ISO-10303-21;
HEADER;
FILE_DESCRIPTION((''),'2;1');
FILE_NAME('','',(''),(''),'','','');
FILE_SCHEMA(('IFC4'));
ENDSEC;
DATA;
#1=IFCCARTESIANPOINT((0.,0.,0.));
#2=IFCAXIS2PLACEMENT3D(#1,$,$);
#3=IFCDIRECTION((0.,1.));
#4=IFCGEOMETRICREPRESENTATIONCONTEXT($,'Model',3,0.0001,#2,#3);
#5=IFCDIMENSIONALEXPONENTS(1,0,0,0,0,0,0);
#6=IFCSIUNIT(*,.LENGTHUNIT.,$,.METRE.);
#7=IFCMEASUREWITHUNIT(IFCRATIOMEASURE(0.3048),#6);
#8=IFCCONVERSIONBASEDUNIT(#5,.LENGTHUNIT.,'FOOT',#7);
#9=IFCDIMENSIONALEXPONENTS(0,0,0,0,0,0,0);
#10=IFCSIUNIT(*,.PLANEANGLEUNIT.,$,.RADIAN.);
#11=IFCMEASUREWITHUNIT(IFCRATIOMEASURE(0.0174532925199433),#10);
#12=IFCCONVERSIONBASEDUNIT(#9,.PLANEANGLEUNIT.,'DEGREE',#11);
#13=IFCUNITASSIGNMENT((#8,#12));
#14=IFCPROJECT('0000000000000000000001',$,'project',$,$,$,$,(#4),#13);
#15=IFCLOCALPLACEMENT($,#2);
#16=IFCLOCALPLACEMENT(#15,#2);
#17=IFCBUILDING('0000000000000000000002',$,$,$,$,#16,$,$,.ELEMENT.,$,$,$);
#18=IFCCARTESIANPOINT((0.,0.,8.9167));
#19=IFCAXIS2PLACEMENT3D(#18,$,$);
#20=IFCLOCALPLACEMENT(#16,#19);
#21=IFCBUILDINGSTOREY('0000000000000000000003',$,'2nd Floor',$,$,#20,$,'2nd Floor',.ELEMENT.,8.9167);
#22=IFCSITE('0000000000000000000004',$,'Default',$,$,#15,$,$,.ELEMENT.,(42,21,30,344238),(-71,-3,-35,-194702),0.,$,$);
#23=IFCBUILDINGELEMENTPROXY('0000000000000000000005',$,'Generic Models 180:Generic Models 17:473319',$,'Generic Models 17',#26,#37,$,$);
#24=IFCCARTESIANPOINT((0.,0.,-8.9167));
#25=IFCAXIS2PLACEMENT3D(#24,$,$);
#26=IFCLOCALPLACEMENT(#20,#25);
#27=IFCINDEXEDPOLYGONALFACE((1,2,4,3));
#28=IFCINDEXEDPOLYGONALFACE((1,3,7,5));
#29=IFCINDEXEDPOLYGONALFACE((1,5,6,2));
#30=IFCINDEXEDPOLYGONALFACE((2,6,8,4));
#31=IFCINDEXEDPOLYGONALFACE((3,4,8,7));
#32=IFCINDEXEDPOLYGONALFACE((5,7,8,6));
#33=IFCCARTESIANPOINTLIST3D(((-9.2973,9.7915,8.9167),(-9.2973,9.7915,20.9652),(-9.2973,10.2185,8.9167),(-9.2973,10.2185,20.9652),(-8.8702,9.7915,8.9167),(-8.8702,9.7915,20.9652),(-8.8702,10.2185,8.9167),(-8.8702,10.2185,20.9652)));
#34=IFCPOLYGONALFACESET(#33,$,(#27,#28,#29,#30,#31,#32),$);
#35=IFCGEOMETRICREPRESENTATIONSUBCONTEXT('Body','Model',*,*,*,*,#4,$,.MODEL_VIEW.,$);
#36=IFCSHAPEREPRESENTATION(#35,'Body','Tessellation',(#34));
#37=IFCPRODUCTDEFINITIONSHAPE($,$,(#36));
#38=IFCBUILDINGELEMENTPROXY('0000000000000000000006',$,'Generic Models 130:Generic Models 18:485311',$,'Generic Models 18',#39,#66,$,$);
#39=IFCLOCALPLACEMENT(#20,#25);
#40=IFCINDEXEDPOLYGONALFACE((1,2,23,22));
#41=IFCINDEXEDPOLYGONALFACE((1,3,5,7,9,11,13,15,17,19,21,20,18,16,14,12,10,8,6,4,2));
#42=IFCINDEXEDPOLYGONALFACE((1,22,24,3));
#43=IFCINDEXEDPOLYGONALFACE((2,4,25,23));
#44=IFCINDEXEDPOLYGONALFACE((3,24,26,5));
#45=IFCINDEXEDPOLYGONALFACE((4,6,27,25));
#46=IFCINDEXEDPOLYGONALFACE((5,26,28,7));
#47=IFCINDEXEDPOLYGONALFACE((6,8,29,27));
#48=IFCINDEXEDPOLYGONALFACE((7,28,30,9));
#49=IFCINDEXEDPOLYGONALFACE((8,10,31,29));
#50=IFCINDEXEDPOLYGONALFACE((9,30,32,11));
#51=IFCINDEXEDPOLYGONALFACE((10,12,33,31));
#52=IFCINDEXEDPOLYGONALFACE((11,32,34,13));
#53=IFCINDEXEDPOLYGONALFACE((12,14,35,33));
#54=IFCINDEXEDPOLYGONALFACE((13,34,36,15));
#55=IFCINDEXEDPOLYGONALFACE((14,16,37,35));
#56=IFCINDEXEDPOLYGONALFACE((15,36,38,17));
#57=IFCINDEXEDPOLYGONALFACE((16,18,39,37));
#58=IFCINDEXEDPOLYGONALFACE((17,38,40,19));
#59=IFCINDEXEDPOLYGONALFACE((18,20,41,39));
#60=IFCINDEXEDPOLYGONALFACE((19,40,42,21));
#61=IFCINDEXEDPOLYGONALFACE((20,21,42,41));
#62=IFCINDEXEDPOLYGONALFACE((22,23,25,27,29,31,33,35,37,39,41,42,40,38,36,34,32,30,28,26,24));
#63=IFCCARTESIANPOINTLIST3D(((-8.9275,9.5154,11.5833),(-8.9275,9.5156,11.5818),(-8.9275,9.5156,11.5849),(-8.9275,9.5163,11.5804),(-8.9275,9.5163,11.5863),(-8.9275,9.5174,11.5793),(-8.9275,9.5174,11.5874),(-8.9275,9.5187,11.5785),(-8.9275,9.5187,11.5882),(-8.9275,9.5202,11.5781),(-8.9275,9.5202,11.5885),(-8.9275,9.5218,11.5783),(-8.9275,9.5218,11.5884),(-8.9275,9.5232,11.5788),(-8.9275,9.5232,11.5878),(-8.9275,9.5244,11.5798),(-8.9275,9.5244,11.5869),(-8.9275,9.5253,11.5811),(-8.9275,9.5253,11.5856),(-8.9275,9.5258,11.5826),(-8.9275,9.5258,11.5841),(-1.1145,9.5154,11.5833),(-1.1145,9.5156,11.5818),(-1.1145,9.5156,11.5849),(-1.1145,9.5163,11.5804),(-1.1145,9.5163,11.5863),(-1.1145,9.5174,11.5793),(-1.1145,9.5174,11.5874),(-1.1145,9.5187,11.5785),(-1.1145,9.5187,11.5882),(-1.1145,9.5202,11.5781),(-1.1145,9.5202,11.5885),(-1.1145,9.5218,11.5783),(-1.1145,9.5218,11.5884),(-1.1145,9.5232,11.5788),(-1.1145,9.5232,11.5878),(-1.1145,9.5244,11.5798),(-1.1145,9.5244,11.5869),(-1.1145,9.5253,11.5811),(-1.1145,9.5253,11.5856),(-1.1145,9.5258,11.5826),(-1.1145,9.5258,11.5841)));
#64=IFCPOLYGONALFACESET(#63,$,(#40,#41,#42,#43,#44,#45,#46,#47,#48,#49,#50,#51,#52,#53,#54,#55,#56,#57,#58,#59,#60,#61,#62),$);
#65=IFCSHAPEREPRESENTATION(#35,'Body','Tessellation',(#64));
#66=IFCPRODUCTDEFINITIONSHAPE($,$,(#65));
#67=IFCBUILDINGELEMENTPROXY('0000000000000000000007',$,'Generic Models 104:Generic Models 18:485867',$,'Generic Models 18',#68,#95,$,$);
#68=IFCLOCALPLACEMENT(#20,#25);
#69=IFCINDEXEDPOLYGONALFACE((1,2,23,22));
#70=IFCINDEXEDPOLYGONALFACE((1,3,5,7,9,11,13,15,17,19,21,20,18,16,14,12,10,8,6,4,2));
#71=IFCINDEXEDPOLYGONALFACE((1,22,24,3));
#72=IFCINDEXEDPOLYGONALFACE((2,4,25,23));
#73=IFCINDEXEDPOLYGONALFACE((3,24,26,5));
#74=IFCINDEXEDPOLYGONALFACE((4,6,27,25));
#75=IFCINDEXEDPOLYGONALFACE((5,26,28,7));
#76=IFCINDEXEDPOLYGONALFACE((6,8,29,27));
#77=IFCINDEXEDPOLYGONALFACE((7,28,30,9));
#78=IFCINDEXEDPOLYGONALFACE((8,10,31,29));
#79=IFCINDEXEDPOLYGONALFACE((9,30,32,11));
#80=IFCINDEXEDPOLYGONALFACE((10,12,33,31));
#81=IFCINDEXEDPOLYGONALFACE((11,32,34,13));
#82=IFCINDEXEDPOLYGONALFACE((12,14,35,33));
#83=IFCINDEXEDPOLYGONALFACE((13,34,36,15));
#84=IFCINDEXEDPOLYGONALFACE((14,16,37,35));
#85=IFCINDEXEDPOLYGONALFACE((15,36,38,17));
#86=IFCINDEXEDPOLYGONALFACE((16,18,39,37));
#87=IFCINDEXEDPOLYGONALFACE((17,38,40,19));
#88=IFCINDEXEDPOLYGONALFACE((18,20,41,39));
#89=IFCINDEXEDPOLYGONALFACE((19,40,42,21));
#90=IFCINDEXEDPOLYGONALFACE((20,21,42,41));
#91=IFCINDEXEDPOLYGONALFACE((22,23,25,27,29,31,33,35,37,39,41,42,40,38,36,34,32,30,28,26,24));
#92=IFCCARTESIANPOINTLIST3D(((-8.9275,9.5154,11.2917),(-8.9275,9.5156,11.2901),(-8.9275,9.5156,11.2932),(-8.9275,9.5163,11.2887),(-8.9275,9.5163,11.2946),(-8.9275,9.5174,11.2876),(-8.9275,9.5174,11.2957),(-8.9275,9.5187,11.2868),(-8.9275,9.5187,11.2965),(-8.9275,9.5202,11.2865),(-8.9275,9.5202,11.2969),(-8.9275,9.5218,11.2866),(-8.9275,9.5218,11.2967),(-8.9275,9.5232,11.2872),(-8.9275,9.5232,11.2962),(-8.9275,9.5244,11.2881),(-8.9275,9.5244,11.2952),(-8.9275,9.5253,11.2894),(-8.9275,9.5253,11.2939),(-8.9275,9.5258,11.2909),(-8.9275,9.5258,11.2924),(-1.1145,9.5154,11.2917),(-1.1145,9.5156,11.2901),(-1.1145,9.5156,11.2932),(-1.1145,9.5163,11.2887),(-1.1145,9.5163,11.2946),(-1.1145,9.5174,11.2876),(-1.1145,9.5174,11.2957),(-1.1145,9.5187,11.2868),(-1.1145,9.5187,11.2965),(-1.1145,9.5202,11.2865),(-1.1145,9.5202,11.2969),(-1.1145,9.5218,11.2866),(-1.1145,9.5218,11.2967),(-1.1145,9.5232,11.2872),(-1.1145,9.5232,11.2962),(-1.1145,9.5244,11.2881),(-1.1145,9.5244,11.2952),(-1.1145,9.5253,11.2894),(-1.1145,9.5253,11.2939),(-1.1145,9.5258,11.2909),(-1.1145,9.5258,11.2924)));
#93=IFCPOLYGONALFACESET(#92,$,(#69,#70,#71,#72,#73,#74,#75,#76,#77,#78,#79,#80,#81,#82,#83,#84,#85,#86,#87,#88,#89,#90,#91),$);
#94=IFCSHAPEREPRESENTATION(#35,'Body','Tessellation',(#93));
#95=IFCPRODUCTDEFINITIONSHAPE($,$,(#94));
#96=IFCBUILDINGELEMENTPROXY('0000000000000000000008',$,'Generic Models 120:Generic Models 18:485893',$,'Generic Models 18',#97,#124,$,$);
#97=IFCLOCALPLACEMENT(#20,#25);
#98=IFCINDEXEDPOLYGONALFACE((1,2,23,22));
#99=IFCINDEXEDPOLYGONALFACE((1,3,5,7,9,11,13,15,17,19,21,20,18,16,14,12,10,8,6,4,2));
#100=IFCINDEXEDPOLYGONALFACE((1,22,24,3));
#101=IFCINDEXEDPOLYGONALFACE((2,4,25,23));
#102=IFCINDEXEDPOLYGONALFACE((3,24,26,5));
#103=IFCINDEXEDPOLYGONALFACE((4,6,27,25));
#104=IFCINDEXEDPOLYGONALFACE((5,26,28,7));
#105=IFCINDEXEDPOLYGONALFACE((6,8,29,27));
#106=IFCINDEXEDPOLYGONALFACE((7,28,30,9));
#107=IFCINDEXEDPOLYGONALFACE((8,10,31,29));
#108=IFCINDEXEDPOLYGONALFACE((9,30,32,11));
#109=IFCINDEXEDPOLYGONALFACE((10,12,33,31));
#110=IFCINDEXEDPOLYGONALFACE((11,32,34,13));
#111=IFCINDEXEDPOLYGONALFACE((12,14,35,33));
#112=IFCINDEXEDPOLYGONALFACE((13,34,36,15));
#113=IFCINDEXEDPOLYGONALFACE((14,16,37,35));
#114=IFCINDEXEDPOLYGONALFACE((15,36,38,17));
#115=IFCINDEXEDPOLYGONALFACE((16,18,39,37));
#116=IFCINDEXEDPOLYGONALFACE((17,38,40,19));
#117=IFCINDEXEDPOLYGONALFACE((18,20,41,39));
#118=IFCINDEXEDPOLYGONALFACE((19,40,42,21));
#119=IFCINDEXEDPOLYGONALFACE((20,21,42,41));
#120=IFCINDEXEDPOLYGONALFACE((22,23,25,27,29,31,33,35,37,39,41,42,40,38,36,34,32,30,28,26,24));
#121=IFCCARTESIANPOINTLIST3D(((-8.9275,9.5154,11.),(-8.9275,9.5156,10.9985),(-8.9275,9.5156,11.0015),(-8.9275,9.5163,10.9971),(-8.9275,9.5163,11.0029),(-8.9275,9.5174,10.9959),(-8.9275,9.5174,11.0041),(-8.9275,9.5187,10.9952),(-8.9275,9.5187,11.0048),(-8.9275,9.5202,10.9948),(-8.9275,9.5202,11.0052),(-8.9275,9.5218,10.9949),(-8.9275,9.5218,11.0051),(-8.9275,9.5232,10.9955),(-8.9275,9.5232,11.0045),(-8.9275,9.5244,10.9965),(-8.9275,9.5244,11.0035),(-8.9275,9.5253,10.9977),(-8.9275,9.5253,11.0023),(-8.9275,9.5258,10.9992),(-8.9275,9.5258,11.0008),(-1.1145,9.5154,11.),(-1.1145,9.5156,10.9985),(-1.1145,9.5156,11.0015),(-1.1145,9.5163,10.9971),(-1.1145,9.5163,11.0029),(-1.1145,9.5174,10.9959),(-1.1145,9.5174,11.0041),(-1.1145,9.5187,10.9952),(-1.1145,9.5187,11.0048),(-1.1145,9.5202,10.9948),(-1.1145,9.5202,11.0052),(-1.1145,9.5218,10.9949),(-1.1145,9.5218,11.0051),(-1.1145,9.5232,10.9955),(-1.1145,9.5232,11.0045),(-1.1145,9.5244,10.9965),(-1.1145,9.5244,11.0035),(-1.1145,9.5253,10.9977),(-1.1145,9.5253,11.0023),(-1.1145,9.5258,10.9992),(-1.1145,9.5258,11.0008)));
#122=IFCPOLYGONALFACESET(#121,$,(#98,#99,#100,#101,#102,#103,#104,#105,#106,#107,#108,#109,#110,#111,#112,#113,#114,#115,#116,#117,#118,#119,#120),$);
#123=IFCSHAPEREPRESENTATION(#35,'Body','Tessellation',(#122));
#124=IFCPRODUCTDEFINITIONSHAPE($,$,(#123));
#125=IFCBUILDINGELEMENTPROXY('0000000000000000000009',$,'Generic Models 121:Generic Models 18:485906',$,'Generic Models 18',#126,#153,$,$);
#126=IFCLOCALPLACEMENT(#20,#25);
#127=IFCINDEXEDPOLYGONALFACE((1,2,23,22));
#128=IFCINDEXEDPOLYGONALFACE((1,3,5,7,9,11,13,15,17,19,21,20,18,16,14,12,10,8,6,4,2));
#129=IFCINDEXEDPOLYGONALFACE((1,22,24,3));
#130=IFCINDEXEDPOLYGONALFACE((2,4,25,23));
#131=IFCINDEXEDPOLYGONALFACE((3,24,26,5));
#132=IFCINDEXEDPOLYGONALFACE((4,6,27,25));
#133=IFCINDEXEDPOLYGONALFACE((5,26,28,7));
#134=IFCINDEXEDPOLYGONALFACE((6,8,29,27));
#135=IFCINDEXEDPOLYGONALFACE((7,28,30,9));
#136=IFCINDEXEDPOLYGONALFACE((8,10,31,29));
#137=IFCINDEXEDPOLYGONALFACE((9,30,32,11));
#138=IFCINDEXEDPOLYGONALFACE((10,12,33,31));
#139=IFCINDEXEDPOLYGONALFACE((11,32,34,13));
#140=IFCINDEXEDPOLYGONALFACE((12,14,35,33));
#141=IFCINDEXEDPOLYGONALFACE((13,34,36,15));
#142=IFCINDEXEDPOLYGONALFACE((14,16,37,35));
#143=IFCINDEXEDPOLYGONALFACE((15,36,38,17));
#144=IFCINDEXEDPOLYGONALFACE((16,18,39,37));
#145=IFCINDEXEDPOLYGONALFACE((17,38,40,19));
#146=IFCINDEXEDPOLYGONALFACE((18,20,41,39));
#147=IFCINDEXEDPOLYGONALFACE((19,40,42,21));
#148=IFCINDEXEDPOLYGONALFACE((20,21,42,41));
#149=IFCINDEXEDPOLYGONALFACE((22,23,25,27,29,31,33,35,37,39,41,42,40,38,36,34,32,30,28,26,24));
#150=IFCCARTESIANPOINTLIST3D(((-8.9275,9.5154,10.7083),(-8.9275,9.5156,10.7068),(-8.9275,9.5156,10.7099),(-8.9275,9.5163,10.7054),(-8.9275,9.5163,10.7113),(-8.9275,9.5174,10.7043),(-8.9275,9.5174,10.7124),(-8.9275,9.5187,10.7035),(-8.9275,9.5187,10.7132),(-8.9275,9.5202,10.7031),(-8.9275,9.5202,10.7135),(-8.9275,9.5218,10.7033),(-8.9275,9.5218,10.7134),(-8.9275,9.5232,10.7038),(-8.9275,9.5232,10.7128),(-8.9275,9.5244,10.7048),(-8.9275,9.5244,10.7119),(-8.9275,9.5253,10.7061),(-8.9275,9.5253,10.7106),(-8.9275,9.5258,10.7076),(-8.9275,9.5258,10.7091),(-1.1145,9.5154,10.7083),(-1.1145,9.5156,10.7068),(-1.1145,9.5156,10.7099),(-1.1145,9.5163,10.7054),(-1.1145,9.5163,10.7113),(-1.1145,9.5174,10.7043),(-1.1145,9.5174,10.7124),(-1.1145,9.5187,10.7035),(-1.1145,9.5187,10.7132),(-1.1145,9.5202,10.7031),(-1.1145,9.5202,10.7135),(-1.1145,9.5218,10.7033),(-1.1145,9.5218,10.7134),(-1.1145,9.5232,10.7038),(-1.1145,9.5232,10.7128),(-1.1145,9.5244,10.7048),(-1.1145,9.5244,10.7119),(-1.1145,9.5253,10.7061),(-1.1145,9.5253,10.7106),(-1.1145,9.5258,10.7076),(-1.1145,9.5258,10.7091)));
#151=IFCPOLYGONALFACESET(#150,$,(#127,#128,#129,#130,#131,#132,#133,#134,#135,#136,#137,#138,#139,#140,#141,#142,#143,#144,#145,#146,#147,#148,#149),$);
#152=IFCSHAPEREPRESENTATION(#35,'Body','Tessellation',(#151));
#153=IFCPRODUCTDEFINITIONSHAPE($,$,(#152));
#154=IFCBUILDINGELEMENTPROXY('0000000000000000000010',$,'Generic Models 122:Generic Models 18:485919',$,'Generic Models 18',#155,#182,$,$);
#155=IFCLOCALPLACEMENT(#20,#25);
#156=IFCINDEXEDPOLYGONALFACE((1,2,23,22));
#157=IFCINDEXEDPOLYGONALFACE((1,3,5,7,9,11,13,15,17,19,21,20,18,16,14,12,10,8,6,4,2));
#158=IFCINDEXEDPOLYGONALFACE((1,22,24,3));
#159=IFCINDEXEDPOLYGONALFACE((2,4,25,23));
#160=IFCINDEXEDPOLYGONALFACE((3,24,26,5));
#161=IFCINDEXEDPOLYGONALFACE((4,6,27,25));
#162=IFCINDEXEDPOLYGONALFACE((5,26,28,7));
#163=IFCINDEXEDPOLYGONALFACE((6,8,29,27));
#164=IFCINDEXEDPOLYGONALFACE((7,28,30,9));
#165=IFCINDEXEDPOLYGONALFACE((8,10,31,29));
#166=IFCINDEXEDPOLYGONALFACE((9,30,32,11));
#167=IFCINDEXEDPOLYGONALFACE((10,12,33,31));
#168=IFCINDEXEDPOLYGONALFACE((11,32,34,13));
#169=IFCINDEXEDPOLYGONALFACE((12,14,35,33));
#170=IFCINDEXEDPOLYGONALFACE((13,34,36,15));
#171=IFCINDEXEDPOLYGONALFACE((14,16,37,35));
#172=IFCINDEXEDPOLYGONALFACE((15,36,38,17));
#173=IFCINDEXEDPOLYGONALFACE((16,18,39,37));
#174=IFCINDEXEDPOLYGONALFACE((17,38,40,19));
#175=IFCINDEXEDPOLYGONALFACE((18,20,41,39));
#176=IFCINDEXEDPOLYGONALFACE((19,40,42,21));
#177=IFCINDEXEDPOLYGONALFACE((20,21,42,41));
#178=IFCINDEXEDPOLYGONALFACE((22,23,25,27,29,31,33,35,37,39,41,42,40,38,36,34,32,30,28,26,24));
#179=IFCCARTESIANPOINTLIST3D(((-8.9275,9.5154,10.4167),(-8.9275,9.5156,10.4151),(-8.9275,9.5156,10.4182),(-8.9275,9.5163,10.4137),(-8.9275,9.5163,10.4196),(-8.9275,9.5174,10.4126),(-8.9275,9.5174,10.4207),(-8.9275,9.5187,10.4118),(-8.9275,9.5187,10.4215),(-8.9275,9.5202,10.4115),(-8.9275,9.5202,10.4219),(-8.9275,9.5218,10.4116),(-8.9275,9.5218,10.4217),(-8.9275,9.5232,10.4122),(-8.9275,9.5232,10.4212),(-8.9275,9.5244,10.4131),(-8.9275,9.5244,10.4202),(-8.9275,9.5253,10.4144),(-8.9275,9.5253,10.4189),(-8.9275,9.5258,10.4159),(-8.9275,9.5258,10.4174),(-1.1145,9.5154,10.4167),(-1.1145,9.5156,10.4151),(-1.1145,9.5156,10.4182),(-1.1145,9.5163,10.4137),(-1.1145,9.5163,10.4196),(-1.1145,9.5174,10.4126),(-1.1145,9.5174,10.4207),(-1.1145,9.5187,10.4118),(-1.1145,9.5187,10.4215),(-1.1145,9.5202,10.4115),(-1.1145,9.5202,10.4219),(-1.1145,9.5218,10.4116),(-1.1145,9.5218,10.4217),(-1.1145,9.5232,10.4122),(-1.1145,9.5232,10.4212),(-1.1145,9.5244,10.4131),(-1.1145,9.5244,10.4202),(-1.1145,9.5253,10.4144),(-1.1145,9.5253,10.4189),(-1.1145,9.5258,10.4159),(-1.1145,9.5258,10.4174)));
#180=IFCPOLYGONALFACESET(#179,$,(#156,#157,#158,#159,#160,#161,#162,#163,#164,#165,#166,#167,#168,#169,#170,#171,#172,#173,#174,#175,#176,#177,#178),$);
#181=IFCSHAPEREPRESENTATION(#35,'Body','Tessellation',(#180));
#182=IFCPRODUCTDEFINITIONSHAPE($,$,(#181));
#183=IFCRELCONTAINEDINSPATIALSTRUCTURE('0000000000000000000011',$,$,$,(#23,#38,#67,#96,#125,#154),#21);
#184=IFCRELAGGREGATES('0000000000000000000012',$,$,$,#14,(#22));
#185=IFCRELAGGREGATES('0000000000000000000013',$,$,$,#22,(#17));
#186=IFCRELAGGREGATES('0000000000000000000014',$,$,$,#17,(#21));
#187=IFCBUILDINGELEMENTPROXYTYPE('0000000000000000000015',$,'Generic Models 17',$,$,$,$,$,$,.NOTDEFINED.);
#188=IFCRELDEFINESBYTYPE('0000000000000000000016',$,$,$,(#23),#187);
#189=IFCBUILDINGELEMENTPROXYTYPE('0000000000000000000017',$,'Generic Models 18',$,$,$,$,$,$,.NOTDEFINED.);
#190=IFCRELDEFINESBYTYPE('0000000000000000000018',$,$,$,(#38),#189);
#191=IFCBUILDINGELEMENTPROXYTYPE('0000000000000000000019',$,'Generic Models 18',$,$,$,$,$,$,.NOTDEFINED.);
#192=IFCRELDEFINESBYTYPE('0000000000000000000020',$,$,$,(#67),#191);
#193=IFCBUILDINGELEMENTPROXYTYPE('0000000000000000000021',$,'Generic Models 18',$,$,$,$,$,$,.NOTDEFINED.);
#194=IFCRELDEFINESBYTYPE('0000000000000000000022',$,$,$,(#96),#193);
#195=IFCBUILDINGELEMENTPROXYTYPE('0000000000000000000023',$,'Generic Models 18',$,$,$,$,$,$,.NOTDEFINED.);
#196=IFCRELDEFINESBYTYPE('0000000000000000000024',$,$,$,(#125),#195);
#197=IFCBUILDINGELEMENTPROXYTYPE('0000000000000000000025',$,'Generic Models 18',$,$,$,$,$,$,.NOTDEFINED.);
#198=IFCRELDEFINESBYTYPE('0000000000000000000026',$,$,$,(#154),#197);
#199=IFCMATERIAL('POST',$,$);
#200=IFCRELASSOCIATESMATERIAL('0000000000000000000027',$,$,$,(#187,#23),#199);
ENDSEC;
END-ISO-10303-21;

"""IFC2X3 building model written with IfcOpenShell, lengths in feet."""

from ifc_helpers import new_model, entity, si_unit, converted_unit, direction, frame, origin, origin_2d_with_axis, place, context, subcontext, project, spatial, rectangle, circle, extrude, source, transform, mapped, material, type_object, type_shapes, element, save


model = new_model("IFC2X3")

# Units and contexts
model_context = context("Model", 3, precision=0.0001, world=origin(), true_north=direction((0.0, 1.0)))
body_context = subcontext(model_context, "Body", "Model", "MODEL_VIEW")
ifc_project = project(units=[converted_unit("LENGTHUNIT", "FOOT", entity("IfcRatioMeasure", 0.3048), si_unit("LENGTHUNIT", "METRE"), dimensions=[1, 0, 0, 0, 0, 0, 0]), converted_unit("PLANEANGLEUNIT", "DEGREE", entity("IfcRatioMeasure", 0.0174532925199433), si_unit("PLANEANGLEUNIT", "RADIAN"), dimensions=[0, 0, 0, 0, 0, 0, 0])], contexts=[model_context])

# Site, building, storey
site_placement = place(None, origin())
site = spatial("IfcSite", under=ifc_project, at=site_placement, Name="Default", CompositionType="ELEMENT", RefLatitude=(42, 21, 30, 344238), RefLongitude=(-71, -3, -35, -194702), RefElevation=0.0)
building_placement = place(site_placement, origin())
building = spatial("IfcBuilding", under=site, at=building_placement, CompositionType="ELEMENT")
storey_placement = place(building_placement, frame((0.0, 0.0, 8.9167)))
storey = spatial("IfcBuildingStorey", under=building, at=storey_placement, Name="2nd Floor", LongName="2nd Floor", CompositionType="ELEMENT", Elevation=8.9167)

# Building element proxies
ifc_material_1 = material(Name="POST")
building_element_proxy_type_1 = type_object("IfcBuildingElementProxyType", Name="Generic Models 17", PredefinedType="NOTDEFINED", material=ifc_material_1)
shared_shape_1 = source(origin(), body_context, "Body", "SweptSolid", [
    extrude(rectangle(XDim=0.4271, YDim=0.4271, at=origin_2d_with_axis()), frame((-9.0837, 10.005, 8.9167), z_axis=(0.0, 0.0, 1.0), x_axis=(0.0, 1.0, 0.0)), (0.0, 0.0, 1.0), 12.0485),
])
type_shapes(building_element_proxy_type_1, [shared_shape_1])
proxy_1_placement = place(storey_placement, frame((0.0, 0.0, -8.9167)))
element("IfcBuildingElementProxy", 1, at=proxy_1_placement, inside=storey, type_object=building_element_proxy_type_1, material=ifc_material_1, Name="Generic Models 180:Generic Models 17:473319", ObjectType="Generic Models 17", context=body_context, shape_type="MappedRepresentation", body=[
    mapped(shared_shape_1, transform((0.0, 0.0, 0.0), scale=1.0)),
])
building_element_proxy_type_2 = type_object("IfcBuildingElementProxyType", Name="Generic Models 18", PredefinedType="NOTDEFINED")
shared_shape_2 = source(origin(), body_context, "Body", "SweptSolid", [
    extrude(circle(Radius=0.0052, at=origin_2d_with_axis()), frame((-8.9275, 9.5206, 11.5833), z_axis=(1.0, 0.0, 0.0), x_axis=(0.0, -1.0, 0.0)), (0.0, 0.0, 1.0), 7.813),
])
type_shapes(building_element_proxy_type_2, [shared_shape_2])
proxy_2_placement = place(storey_placement, frame((0.0, 0.0, -8.9167)))
element("IfcBuildingElementProxy", 2, at=proxy_2_placement, inside=storey, type_object=building_element_proxy_type_2, Name="Generic Models 130:Generic Models 18:485311", ObjectType="Generic Models 18", context=body_context, shape_type="MappedRepresentation", body=[
    mapped(shared_shape_2, transform((0.0, 0.0, 0.0), scale=1.0)),
])
building_element_proxy_type_3 = type_object("IfcBuildingElementProxyType", Name="Generic Models 18", PredefinedType="NOTDEFINED")
shared_shape_3 = source(origin(), body_context, "Body", "SweptSolid", [
    extrude(circle(Radius=0.0052, at=origin_2d_with_axis()), frame((-8.9275, 9.5206, 11.2917), z_axis=(1.0, 0.0, 0.0), x_axis=(0.0, -1.0, 0.0)), (0.0, 0.0, 1.0), 7.813),
])
type_shapes(building_element_proxy_type_3, [shared_shape_3])
proxy_3_placement = place(storey_placement, frame((0.0, 0.0, -8.9167)))
element("IfcBuildingElementProxy", 3, at=proxy_3_placement, inside=storey, type_object=building_element_proxy_type_3, Name="Generic Models 104:Generic Models 18:485867", ObjectType="Generic Models 18", context=body_context, shape_type="MappedRepresentation", body=[
    mapped(shared_shape_3, transform((0.0, 0.0, 0.0), scale=1.0)),
])
building_element_proxy_type_4 = type_object("IfcBuildingElementProxyType", Name="Generic Models 18", PredefinedType="NOTDEFINED")
shared_shape_4 = source(origin(), body_context, "Body", "SweptSolid", [
    extrude(circle(Radius=0.0052, at=origin_2d_with_axis()), frame((-8.9275, 9.5206, 11.0), z_axis=(1.0, 0.0, 0.0), x_axis=(0.0, -1.0, 0.0)), (0.0, 0.0, 1.0), 7.813),
])
type_shapes(building_element_proxy_type_4, [shared_shape_4])
proxy_4_placement = place(storey_placement, frame((0.0, 0.0, -8.9167)))
element("IfcBuildingElementProxy", 4, at=proxy_4_placement, inside=storey, type_object=building_element_proxy_type_4, Name="Generic Models 120:Generic Models 18:485893", ObjectType="Generic Models 18", context=body_context, shape_type="MappedRepresentation", body=[
    mapped(shared_shape_4, transform((0.0, 0.0, 0.0), scale=1.0)),
])
building_element_proxy_type_5 = type_object("IfcBuildingElementProxyType", Name="Generic Models 18", PredefinedType="NOTDEFINED")
shared_shape_5 = source(origin(), body_context, "Body", "SweptSolid", [
    extrude(circle(Radius=0.0052, at=origin_2d_with_axis()), frame((-8.9275, 9.5206, 10.7083), z_axis=(1.0, 0.0, 0.0), x_axis=(0.0, -1.0, 0.0)), (0.0, 0.0, 1.0), 7.813),
])
type_shapes(building_element_proxy_type_5, [shared_shape_5])
proxy_5_placement = place(storey_placement, frame((0.0, 0.0, -8.9167)))
element("IfcBuildingElementProxy", 5, at=proxy_5_placement, inside=storey, type_object=building_element_proxy_type_5, Name="Generic Models 121:Generic Models 18:485906", ObjectType="Generic Models 18", context=body_context, shape_type="MappedRepresentation", body=[
    mapped(shared_shape_5, transform((0.0, 0.0, 0.0), scale=1.0)),
])
building_element_proxy_type_6 = type_object("IfcBuildingElementProxyType", Name="Generic Models 18", PredefinedType="NOTDEFINED")
shared_shape_6 = source(origin(), body_context, "Body", "SweptSolid", [
    extrude(circle(Radius=0.0052, at=origin_2d_with_axis()), frame((-8.9275, 9.5206, 10.4167), z_axis=(1.0, 0.0, 0.0), x_axis=(0.0, -1.0, 0.0)), (0.0, 0.0, 1.0), 7.813),
])
type_shapes(building_element_proxy_type_6, [shared_shape_6])
proxy_6_placement = place(storey_placement, frame((0.0, 0.0, -8.9167)))
element("IfcBuildingElementProxy", 6, at=proxy_6_placement, inside=storey, type_object=building_element_proxy_type_6, Name="Generic Models 122:Generic Models 18:485919", ObjectType="Generic Models 18", context=body_context, shape_type="MappedRepresentation", body=[
    mapped(shared_shape_6, transform((0.0, 0.0, 0.0), scale=1.0)),
])

save(model, "model.ifc")
